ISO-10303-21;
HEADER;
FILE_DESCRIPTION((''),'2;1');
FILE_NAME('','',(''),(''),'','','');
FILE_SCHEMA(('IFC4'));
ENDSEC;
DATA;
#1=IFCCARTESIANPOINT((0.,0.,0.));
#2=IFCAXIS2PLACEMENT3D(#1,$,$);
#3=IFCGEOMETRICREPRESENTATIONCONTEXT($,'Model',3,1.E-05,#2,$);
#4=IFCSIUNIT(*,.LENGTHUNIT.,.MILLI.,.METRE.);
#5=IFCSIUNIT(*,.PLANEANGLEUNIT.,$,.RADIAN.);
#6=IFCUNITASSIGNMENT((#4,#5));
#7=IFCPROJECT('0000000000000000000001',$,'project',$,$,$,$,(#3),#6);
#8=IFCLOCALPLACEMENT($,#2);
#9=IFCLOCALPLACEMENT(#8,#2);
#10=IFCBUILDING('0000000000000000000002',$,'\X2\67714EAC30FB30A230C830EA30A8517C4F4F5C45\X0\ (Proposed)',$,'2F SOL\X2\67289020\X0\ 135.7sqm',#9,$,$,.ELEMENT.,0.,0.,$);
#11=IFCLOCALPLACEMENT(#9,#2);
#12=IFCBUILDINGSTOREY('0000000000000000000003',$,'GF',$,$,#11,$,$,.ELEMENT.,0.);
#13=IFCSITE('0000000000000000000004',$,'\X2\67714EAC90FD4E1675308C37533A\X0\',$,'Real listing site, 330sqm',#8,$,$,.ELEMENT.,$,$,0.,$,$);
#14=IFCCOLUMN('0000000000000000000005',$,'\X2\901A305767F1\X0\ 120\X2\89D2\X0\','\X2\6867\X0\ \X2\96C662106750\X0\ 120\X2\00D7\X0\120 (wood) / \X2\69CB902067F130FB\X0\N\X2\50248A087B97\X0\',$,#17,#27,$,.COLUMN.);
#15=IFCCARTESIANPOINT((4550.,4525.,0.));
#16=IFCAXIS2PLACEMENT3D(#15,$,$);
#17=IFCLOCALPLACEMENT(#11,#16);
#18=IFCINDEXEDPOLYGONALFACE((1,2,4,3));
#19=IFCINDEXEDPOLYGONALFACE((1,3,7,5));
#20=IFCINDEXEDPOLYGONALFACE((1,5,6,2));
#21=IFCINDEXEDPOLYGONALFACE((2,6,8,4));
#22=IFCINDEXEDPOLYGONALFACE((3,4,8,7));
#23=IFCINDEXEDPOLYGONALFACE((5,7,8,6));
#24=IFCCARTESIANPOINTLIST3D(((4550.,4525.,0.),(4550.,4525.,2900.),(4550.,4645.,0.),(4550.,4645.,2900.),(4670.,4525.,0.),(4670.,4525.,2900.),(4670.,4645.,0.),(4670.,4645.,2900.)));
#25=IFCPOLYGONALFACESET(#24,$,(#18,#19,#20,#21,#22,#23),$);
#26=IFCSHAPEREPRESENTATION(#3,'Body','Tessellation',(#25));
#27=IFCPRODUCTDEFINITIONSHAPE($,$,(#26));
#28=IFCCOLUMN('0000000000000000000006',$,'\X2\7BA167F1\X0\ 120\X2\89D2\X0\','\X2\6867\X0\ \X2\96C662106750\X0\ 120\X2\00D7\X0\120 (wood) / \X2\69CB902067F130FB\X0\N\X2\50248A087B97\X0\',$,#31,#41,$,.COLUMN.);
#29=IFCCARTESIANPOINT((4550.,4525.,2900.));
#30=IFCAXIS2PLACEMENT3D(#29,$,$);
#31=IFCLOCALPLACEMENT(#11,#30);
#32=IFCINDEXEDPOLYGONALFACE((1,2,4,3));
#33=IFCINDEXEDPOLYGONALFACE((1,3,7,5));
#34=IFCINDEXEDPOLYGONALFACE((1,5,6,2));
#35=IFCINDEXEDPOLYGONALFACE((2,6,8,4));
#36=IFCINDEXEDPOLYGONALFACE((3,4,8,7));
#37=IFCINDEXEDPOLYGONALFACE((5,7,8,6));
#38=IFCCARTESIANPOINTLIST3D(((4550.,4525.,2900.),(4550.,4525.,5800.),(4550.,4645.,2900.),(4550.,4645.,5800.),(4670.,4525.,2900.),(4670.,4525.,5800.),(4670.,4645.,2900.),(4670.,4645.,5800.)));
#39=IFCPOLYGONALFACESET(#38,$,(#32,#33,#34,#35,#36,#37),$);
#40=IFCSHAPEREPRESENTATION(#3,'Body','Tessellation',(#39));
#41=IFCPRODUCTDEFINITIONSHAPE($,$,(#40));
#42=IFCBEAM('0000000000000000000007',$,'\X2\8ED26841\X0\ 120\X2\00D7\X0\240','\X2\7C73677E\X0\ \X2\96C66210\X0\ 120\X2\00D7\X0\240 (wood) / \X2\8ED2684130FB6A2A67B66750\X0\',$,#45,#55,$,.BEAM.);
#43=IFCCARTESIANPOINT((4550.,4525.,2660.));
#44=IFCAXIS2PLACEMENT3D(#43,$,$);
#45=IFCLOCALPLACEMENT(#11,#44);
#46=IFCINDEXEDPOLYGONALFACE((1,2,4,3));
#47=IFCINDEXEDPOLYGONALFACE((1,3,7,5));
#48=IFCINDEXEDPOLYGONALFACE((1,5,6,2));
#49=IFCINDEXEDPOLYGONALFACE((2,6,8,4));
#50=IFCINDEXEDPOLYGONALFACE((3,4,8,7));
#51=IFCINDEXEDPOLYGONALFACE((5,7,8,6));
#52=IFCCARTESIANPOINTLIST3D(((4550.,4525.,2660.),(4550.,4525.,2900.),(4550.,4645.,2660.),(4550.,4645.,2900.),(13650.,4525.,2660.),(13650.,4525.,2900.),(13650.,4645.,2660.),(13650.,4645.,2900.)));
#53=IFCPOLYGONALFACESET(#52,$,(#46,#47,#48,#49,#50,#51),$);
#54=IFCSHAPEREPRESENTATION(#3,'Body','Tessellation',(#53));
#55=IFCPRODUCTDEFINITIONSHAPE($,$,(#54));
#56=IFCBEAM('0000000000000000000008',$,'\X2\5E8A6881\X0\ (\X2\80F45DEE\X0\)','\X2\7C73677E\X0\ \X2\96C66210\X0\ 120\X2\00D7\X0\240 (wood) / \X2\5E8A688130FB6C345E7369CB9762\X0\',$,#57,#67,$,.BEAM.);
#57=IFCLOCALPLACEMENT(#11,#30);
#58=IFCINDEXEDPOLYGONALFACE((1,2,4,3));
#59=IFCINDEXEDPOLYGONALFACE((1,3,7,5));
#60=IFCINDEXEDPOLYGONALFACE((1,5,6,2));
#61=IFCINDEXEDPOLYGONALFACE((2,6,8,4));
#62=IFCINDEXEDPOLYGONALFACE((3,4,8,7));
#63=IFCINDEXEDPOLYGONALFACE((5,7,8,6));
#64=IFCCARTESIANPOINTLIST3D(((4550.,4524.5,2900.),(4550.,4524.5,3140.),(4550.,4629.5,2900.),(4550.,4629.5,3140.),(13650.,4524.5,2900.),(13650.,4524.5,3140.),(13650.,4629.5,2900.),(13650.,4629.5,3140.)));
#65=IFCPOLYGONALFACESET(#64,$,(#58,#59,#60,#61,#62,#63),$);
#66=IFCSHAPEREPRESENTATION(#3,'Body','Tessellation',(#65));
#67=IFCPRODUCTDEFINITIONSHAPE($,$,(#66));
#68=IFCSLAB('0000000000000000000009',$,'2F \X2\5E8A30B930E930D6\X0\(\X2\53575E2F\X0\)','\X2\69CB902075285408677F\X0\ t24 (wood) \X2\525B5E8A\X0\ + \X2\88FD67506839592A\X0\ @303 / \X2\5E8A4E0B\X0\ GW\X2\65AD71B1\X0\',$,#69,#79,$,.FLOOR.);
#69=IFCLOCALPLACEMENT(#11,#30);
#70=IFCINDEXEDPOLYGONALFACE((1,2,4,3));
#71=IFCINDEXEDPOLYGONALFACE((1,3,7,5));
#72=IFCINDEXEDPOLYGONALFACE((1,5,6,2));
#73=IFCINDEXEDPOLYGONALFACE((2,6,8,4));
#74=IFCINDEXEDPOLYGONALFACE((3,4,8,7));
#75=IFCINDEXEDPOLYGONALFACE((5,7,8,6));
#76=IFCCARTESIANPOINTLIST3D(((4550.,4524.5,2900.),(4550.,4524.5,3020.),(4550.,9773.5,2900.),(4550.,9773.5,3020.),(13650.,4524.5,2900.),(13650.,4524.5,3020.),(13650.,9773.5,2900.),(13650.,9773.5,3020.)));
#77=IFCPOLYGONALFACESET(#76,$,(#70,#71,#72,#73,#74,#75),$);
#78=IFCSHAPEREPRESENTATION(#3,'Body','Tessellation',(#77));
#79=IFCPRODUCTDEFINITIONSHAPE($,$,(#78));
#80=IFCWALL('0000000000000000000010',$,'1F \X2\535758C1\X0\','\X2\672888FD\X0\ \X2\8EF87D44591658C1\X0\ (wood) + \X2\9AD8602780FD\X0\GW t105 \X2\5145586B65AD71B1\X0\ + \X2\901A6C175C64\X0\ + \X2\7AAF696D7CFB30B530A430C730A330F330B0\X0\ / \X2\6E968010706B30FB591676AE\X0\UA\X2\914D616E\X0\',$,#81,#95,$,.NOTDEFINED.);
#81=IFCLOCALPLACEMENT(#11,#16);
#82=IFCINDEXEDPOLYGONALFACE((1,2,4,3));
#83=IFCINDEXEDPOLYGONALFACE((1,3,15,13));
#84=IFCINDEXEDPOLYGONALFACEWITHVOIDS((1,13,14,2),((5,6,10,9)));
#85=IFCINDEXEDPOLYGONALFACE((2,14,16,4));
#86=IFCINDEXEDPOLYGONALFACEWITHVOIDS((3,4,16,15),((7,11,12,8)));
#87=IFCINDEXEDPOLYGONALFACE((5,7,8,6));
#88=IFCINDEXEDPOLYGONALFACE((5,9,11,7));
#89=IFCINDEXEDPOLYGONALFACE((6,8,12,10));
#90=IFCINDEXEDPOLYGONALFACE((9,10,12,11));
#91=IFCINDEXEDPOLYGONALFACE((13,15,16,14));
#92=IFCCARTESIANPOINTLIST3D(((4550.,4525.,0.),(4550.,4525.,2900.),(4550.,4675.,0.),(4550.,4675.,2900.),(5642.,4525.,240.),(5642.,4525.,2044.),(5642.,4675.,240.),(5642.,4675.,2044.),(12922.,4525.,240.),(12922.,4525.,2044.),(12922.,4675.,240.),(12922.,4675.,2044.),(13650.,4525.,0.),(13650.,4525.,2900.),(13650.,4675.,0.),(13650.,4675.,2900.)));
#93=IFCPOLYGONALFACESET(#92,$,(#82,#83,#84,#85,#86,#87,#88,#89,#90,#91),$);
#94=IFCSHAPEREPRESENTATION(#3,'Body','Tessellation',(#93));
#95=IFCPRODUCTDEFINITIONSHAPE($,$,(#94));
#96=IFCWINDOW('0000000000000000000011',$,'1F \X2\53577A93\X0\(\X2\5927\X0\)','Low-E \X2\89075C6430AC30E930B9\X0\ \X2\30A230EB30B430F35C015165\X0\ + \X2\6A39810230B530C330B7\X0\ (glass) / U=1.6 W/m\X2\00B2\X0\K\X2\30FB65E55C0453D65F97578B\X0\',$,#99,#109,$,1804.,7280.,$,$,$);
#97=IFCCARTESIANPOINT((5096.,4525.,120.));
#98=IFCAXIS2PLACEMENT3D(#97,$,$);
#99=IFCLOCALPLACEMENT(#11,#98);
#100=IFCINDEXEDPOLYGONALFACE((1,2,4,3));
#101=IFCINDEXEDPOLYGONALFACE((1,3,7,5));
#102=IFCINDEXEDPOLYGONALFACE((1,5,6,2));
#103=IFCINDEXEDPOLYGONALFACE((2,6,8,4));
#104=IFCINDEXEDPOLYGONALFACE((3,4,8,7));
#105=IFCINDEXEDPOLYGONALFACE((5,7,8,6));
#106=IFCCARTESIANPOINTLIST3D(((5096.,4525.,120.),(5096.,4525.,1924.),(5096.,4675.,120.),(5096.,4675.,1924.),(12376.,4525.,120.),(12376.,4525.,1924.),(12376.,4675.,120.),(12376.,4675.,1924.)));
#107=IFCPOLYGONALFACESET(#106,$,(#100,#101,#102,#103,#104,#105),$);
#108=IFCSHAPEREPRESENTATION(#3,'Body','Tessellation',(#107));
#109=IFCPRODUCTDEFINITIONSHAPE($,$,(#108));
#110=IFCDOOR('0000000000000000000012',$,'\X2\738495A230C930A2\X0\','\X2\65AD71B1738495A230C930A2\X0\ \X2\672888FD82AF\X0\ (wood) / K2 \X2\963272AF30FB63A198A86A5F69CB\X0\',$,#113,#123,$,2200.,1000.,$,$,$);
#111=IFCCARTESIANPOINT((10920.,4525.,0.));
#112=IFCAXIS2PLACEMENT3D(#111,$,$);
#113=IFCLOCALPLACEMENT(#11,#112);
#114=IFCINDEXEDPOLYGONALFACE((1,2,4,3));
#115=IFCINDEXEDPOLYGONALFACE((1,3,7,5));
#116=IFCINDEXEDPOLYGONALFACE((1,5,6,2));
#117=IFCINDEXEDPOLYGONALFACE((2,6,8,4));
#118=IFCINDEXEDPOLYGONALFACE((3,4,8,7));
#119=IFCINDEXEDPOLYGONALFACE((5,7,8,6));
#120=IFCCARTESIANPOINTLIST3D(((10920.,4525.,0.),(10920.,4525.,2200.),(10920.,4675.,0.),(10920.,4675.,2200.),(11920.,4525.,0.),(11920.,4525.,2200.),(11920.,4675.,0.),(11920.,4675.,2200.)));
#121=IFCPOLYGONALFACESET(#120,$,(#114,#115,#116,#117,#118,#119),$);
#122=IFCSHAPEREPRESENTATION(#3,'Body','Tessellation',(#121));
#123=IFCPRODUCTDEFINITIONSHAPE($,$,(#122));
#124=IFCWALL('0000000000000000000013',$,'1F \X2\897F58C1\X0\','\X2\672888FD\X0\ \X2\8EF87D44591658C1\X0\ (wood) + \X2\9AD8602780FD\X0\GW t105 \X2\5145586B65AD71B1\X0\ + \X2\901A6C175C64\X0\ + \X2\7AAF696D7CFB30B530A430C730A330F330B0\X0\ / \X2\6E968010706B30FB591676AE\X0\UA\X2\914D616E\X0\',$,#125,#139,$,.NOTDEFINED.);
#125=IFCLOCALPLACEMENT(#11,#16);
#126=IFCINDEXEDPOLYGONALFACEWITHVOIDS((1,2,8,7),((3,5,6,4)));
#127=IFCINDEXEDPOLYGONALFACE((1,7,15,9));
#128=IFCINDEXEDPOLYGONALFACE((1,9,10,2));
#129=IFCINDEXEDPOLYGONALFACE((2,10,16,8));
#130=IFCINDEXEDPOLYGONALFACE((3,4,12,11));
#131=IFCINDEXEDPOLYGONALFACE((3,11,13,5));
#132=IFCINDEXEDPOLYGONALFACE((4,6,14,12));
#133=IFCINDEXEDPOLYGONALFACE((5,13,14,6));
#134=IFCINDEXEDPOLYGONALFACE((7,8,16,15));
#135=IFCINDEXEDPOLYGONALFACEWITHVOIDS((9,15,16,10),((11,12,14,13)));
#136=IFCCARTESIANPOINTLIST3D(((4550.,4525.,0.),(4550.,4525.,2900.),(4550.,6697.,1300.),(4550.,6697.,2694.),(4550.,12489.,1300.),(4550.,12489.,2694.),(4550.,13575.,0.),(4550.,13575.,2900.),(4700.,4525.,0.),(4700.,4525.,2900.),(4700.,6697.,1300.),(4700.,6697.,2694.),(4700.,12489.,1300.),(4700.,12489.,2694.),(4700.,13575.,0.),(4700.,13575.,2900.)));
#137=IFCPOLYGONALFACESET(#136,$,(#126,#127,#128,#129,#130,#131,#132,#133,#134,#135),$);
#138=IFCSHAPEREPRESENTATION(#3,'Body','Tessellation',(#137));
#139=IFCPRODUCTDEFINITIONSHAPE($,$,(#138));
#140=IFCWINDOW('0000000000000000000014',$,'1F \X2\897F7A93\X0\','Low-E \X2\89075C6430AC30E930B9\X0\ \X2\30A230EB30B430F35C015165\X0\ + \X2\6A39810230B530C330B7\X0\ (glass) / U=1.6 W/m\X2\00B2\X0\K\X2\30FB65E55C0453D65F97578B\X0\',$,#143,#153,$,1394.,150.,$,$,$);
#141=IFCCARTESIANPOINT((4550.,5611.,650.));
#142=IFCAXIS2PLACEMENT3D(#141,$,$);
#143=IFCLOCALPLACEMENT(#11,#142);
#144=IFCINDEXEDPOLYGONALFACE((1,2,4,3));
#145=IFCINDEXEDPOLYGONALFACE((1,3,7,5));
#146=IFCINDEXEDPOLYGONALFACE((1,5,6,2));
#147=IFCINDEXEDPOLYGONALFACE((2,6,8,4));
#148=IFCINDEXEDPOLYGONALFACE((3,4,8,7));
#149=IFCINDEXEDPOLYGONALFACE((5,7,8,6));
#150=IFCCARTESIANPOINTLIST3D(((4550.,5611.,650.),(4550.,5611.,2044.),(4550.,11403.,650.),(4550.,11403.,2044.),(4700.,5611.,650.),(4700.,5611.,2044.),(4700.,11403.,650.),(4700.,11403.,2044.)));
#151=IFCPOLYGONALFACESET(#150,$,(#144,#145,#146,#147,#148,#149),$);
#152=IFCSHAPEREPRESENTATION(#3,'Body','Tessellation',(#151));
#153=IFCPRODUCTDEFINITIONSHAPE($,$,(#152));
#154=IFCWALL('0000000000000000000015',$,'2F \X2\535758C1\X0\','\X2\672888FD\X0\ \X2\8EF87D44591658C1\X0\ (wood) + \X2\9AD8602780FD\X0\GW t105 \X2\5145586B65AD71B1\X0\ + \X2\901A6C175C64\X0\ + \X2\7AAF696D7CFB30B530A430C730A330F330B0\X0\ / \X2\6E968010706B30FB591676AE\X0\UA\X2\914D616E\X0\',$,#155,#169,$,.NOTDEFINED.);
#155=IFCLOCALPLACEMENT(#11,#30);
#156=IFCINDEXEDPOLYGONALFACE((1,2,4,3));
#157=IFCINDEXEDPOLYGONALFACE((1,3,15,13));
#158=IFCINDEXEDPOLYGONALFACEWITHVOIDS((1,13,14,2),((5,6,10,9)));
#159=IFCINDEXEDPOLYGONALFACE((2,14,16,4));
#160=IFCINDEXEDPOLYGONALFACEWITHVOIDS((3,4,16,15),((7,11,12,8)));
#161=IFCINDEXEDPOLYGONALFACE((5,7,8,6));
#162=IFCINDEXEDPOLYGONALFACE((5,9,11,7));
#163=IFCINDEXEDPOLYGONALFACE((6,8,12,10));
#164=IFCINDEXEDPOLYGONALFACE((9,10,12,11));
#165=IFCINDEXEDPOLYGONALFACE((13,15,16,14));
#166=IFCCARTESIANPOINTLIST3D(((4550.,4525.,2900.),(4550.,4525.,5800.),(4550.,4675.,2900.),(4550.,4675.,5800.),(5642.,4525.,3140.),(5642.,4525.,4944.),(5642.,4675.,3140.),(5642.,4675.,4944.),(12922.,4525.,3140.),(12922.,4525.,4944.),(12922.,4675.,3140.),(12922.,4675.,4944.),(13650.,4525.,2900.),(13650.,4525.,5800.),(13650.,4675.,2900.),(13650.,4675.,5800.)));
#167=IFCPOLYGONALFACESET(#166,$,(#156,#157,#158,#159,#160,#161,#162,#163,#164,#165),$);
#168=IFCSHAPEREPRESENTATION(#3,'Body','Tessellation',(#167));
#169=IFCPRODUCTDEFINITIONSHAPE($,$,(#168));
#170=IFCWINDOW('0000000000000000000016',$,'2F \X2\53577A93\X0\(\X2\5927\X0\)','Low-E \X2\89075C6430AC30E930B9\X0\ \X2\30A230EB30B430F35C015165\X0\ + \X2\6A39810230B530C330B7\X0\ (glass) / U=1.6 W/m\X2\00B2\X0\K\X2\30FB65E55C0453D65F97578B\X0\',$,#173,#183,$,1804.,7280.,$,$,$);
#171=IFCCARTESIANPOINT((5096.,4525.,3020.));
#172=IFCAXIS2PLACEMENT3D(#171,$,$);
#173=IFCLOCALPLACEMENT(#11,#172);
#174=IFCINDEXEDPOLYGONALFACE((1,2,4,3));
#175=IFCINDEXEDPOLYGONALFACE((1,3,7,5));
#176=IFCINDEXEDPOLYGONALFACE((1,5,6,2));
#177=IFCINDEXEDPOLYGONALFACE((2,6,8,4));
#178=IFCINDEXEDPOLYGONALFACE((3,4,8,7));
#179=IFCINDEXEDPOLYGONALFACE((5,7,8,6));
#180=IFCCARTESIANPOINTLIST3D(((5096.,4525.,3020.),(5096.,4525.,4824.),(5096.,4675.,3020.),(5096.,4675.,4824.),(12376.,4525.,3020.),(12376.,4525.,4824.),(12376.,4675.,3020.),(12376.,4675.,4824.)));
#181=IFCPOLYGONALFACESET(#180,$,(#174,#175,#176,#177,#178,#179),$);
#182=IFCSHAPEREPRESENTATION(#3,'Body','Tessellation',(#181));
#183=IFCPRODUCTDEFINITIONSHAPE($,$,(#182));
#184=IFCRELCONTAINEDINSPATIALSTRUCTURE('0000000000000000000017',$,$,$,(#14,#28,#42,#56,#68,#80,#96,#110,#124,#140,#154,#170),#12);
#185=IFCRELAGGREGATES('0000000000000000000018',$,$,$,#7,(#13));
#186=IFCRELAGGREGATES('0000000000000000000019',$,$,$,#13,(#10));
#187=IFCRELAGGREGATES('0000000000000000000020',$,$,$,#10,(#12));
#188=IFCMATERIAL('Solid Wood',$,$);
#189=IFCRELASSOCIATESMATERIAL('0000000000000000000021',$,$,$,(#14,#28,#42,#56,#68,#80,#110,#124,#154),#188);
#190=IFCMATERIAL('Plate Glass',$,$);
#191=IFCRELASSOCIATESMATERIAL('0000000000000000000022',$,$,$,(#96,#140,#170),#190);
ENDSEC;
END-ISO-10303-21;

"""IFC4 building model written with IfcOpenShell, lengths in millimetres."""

from ifc_helpers import new_model, si_unit, frame, frame_2d, origin, place, context, project, spatial, rectangle, extrude, material, element, fill, save


model = new_model("IFC4")

# Units and contexts
model_context = context("Model", 3, precision=1e-05, world=origin())
ifc_project = project(units=[si_unit("LENGTHUNIT", "METRE", prefix="MILLI"), si_unit("PLANEANGLEUNIT", "RADIAN")], contexts=[model_context])

# Site, building, storey
site_placement = place(None, origin())
site = spatial("IfcSite", under=ifc_project, at=site_placement, Name="東京都世田谷区", ObjectType="Real listing site, 330sqm", CompositionType="ELEMENT", RefElevation=0.0)
building_placement = place(site_placement, origin())
building = spatial("IfcBuilding", under=site, at=building_placement, Name="東京・アトリエ兼住居 (Proposed)", ObjectType="2F SOL木造 135.7sqm", CompositionType="ELEMENT", ElevationOfRefHeight=0.0, ElevationOfTerrain=0.0)
storey_placement = place(building_placement, origin())
storey = spatial("IfcBuildingStorey", under=building, at=storey_placement, Name="GF", CompositionType="ELEMENT", Elevation=0.0)

# Columns
ifc_material_1 = material(Name="Solid Wood")
column_1_placement = place(storey_placement, frame((4550.0, 4525.0, 0.0)))
element("IfcColumn", 1, at=column_1_placement, inside=storey, material=ifc_material_1, Name="通し柱 120角", Description="桧 集成材 120×120 (wood) / 構造柱・N値計算", PredefinedType="COLUMN", context=model_context, shape_type="SweptSolid", body=[
    extrude(rectangle(XDim=120.0, YDim=120.0, at=frame_2d((60.0, 60.0))), frame((4550.0, 4525.0, 0.0)), (0.0, 0.0, 1.0), 2900.0),
])
column_2_placement = place(storey_placement, frame((4550.0, 4525.0, 2900.0)))
element("IfcColumn", 2, at=column_2_placement, inside=storey, material=ifc_material_1, Name="管柱 120角", Description="桧 集成材 120×120 (wood) / 構造柱・N値計算", PredefinedType="COLUMN", context=model_context, shape_type="SweptSolid", body=[
    extrude(rectangle(XDim=120.0, YDim=120.0, at=frame_2d((60.0, 60.0))), frame((4550.0, 4525.0, 2900.0)), (0.0, 0.0, 1.0), 2900.0),
])

# Beams
beam_1_placement = place(storey_placement, frame((4550.0, 4525.0, 2660.0)))
element("IfcBeam", 3, at=beam_1_placement, inside=storey, material=ifc_material_1, Name="軒桁 120×240", Description="米松 集成 120×240 (wood) / 軒桁・横架材", PredefinedType="BEAM", context=model_context, shape_type="SweptSolid", body=[
    extrude(rectangle(XDim=9100.0, YDim=120.0, at=frame_2d((4550.0, 60.0))), frame((4550.0, 4525.0, 2660.0)), (0.0, 0.0, 1.0), 240.0),
])
beam_2_placement = place(storey_placement, frame((4550.0, 4525.0, 2900.0)))
element("IfcBeam", 4, at=beam_2_placement, inside=storey, material=ifc_material_1, Name="床梁 (胴差)", Description="米松 集成 120×240 (wood) / 床梁・水平構面", PredefinedType="BEAM", context=model_context, shape_type="SweptSolid", body=[
    extrude(rectangle(XDim=9100.0, YDim=105.0, at=frame_2d((4550.0, 52.0))), frame((4550.0, 4525.0, 2900.0)), (0.0, 0.0, 1.0), 240.0),
])

# Slab
slab_1_placement = place(storey_placement, frame((4550.0, 4525.0, 2900.0)))
element("IfcSlab", 5, at=slab_1_placement, inside=storey, material=ifc_material_1, Name="2F 床スラブ(南帯)", Description="構造用合板 t24 (wood) 剛床 + 製材根太 @303 / 床下 GW断熱", PredefinedType="FLOOR", context=model_context, shape_type="SweptSolid", body=[
    extrude(rectangle(XDim=9100.0, YDim=5249.0, at=frame_2d((4550.0, 2624.0))), frame((4550.0, 4525.0, 2900.0)), (0.0, 0.0, 1.0), 120.0),
])

# Wall, openings, window, door
wall_1_placement = place(storey_placement, frame((4550.0, 4525.0, 0.0)))
wall_1 = element("IfcWall", 6, at=wall_1_placement, inside=storey, material=ifc_material_1, Name="1F 南壁", Description="木製 軸組外壁 (wood) + 高性能GW t105 充填断熱 + 通気層 + 窯業系サイディング / 準耐火・外皮UA配慮", PredefinedType="NOTDEFINED", context=model_context, shape_type="SweptSolid", body=[
    extrude(rectangle(XDim=9100.0, YDim=150.0, at=frame_2d((4550.0, 75.0))), frame((4550.0, 4525.0, 0.0)), (0.0, 0.0, 1.0), 2900.0),
])
opening_1_placement = place(storey_placement, frame((5096.0, 4525.0, 120.0)))
opening_1 = element("IfcOpeningElement", 7, at=opening_1_placement, cuts=wall_1, PredefinedType="NOTDEFINED", context=model_context, shape_type="SweptSolid", body=[
    extrude(rectangle(XDim=7280.0, YDim=150.0, at=frame_2d((3640.0, 75.0))), frame((5096.0, 4525.0, 120.0)), (0.0, 0.0, 1.0), 1804.0),
])
opening_2_placement = place(storey_placement, frame((10920.0, 4525.0, 0.0)))
opening_2 = element("IfcOpeningElement", 8, at=opening_2_placement, cuts=wall_1, PredefinedType="NOTDEFINED", context=model_context, shape_type="SweptSolid", body=[
    extrude(rectangle(XDim=1000.0, YDim=150.0, at=frame_2d((500.0, 75.0))), frame((10920.0, 4525.0, 0.0)), (0.0, 0.0, 1.0), 2200.0),
])
ifc_material_2 = material(Name="Plate Glass")
window_1_placement = place(storey_placement, frame((5096.0, 4525.0, 120.0)))
window_1 = element("IfcWindow", 9, at=window_1_placement, inside=storey, material=ifc_material_2, Name="1F 南窓(大)", Description="Low-E 複層ガラス アルゴン封入 + 樹脂サッシ (glass) / U=1.6 W/m²K・日射取得型", OverallHeight=1804.0, OverallWidth=7280.0, context=model_context, shape_type="SweptSolid", body=[
    extrude(rectangle(XDim=7280.0, YDim=150.0, at=frame_2d((3640.0, 75.0))), frame((5096.0, 4525.0, 120.0)), (0.0, 0.0, 1.0), 1804.0),
])
fill(opening_1, window_1)
door_placement = place(storey_placement, frame((10920.0, 4525.0, 0.0)))
door = element("IfcDoor", 10, at=door_placement, inside=storey, material=ifc_material_1, Name="玄関ドア", Description="断熱玄関ドア 木製芯 (wood) / K2 防犯・採風機構", OverallHeight=2200.0, OverallWidth=1000.0, context=model_context, shape_type="SweptSolid", body=[
    extrude(rectangle(XDim=1000.0, YDim=150.0, at=frame_2d((500.0, 75.0))), frame((10920.0, 4525.0, 0.0)), (0.0, 0.0, 1.0), 2200.0),
])
fill(opening_2, door)

# Walls, openings, windows
wall_2_placement = place(storey_placement, frame((4550.0, 4525.0, 0.0)))
wall_2 = element("IfcWall", 11, at=wall_2_placement, inside=storey, material=ifc_material_1, Name="1F 西壁", Description="木製 軸組外壁 (wood) + 高性能GW t105 充填断熱 + 通気層 + 窯業系サイディング / 準耐火・外皮UA配慮", PredefinedType="NOTDEFINED", context=model_context, shape_type="SweptSolid", body=[
    extrude(rectangle(XDim=150.0, YDim=9050.0, at=frame_2d((75.0, 4525.0))), frame((4550.0, 4525.0, 0.0)), (0.0, 0.0, 1.0), 2900.0),
])
opening_3_placement = place(storey_placement, frame((4550.0, 5611.0, 650.0)))
opening_3 = element("IfcOpeningElement", 12, at=opening_3_placement, cuts=wall_2, PredefinedType="NOTDEFINED", context=model_context, shape_type="SweptSolid", body=[
    extrude(rectangle(XDim=150.0, YDim=5792.0, at=frame_2d((75.0, 2896.0))), frame((4550.0, 5611.0, 650.0)), (0.0, 0.0, 1.0), 1394.0),
])
window_2_placement = place(storey_placement, frame((4550.0, 5611.0, 650.0)))
window_2 = element("IfcWindow", 13, at=window_2_placement, inside=storey, material=ifc_material_2, Name="1F 西窓", Description="Low-E 複層ガラス アルゴン封入 + 樹脂サッシ (glass) / U=1.6 W/m²K・日射取得型", OverallHeight=1394.0, OverallWidth=150.0, context=model_context, shape_type="SweptSolid", body=[
    extrude(rectangle(XDim=150.0, YDim=5792.0, at=frame_2d((75.0, 2896.0))), frame((4550.0, 5611.0, 650.0)), (0.0, 0.0, 1.0), 1394.0),
])
fill(opening_3, window_2)
wall_3_placement = place(storey_placement, frame((4550.0, 4525.0, 2900.0)))
wall_3 = element("IfcWall", 14, at=wall_3_placement, inside=storey, material=ifc_material_1, Name="2F 南壁", Description="木製 軸組外壁 (wood) + 高性能GW t105 充填断熱 + 通気層 + 窯業系サイディング / 準耐火・外皮UA配慮", PredefinedType="NOTDEFINED", context=model_context, shape_type="SweptSolid", body=[
    extrude(rectangle(XDim=9100.0, YDim=150.0, at=frame_2d((4550.0, 75.0))), frame((4550.0, 4525.0, 2900.0)), (0.0, 0.0, 1.0), 2900.0),
])
opening_4_placement = place(storey_placement, frame((5096.0, 4525.0, 3020.0)))
opening_4 = element("IfcOpeningElement", 15, at=opening_4_placement, cuts=wall_3, PredefinedType="NOTDEFINED", context=model_context, shape_type="SweptSolid", body=[
    extrude(rectangle(XDim=7280.0, YDim=150.0, at=frame_2d((3640.0, 75.0))), frame((5096.0, 4525.0, 3020.0)), (0.0, 0.0, 1.0), 1804.0),
])
window_3_placement = place(storey_placement, frame((5096.0, 4525.0, 3020.0)))
window_3 = element("IfcWindow", 16, at=window_3_placement, inside=storey, material=ifc_material_2, Name="2F 南窓(大)", Description="Low-E 複層ガラス アルゴン封入 + 樹脂サッシ (glass) / U=1.6 W/m²K・日射取得型", OverallHeight=1804.0, OverallWidth=7280.0, context=model_context, shape_type="SweptSolid", body=[
    extrude(rectangle(XDim=7280.0, YDim=150.0, at=frame_2d((3640.0, 75.0))), frame((5096.0, 4525.0, 3020.0)), (0.0, 0.0, 1.0), 1804.0),
])
fill(opening_4, window_3)

save(model, "model.ifc")
